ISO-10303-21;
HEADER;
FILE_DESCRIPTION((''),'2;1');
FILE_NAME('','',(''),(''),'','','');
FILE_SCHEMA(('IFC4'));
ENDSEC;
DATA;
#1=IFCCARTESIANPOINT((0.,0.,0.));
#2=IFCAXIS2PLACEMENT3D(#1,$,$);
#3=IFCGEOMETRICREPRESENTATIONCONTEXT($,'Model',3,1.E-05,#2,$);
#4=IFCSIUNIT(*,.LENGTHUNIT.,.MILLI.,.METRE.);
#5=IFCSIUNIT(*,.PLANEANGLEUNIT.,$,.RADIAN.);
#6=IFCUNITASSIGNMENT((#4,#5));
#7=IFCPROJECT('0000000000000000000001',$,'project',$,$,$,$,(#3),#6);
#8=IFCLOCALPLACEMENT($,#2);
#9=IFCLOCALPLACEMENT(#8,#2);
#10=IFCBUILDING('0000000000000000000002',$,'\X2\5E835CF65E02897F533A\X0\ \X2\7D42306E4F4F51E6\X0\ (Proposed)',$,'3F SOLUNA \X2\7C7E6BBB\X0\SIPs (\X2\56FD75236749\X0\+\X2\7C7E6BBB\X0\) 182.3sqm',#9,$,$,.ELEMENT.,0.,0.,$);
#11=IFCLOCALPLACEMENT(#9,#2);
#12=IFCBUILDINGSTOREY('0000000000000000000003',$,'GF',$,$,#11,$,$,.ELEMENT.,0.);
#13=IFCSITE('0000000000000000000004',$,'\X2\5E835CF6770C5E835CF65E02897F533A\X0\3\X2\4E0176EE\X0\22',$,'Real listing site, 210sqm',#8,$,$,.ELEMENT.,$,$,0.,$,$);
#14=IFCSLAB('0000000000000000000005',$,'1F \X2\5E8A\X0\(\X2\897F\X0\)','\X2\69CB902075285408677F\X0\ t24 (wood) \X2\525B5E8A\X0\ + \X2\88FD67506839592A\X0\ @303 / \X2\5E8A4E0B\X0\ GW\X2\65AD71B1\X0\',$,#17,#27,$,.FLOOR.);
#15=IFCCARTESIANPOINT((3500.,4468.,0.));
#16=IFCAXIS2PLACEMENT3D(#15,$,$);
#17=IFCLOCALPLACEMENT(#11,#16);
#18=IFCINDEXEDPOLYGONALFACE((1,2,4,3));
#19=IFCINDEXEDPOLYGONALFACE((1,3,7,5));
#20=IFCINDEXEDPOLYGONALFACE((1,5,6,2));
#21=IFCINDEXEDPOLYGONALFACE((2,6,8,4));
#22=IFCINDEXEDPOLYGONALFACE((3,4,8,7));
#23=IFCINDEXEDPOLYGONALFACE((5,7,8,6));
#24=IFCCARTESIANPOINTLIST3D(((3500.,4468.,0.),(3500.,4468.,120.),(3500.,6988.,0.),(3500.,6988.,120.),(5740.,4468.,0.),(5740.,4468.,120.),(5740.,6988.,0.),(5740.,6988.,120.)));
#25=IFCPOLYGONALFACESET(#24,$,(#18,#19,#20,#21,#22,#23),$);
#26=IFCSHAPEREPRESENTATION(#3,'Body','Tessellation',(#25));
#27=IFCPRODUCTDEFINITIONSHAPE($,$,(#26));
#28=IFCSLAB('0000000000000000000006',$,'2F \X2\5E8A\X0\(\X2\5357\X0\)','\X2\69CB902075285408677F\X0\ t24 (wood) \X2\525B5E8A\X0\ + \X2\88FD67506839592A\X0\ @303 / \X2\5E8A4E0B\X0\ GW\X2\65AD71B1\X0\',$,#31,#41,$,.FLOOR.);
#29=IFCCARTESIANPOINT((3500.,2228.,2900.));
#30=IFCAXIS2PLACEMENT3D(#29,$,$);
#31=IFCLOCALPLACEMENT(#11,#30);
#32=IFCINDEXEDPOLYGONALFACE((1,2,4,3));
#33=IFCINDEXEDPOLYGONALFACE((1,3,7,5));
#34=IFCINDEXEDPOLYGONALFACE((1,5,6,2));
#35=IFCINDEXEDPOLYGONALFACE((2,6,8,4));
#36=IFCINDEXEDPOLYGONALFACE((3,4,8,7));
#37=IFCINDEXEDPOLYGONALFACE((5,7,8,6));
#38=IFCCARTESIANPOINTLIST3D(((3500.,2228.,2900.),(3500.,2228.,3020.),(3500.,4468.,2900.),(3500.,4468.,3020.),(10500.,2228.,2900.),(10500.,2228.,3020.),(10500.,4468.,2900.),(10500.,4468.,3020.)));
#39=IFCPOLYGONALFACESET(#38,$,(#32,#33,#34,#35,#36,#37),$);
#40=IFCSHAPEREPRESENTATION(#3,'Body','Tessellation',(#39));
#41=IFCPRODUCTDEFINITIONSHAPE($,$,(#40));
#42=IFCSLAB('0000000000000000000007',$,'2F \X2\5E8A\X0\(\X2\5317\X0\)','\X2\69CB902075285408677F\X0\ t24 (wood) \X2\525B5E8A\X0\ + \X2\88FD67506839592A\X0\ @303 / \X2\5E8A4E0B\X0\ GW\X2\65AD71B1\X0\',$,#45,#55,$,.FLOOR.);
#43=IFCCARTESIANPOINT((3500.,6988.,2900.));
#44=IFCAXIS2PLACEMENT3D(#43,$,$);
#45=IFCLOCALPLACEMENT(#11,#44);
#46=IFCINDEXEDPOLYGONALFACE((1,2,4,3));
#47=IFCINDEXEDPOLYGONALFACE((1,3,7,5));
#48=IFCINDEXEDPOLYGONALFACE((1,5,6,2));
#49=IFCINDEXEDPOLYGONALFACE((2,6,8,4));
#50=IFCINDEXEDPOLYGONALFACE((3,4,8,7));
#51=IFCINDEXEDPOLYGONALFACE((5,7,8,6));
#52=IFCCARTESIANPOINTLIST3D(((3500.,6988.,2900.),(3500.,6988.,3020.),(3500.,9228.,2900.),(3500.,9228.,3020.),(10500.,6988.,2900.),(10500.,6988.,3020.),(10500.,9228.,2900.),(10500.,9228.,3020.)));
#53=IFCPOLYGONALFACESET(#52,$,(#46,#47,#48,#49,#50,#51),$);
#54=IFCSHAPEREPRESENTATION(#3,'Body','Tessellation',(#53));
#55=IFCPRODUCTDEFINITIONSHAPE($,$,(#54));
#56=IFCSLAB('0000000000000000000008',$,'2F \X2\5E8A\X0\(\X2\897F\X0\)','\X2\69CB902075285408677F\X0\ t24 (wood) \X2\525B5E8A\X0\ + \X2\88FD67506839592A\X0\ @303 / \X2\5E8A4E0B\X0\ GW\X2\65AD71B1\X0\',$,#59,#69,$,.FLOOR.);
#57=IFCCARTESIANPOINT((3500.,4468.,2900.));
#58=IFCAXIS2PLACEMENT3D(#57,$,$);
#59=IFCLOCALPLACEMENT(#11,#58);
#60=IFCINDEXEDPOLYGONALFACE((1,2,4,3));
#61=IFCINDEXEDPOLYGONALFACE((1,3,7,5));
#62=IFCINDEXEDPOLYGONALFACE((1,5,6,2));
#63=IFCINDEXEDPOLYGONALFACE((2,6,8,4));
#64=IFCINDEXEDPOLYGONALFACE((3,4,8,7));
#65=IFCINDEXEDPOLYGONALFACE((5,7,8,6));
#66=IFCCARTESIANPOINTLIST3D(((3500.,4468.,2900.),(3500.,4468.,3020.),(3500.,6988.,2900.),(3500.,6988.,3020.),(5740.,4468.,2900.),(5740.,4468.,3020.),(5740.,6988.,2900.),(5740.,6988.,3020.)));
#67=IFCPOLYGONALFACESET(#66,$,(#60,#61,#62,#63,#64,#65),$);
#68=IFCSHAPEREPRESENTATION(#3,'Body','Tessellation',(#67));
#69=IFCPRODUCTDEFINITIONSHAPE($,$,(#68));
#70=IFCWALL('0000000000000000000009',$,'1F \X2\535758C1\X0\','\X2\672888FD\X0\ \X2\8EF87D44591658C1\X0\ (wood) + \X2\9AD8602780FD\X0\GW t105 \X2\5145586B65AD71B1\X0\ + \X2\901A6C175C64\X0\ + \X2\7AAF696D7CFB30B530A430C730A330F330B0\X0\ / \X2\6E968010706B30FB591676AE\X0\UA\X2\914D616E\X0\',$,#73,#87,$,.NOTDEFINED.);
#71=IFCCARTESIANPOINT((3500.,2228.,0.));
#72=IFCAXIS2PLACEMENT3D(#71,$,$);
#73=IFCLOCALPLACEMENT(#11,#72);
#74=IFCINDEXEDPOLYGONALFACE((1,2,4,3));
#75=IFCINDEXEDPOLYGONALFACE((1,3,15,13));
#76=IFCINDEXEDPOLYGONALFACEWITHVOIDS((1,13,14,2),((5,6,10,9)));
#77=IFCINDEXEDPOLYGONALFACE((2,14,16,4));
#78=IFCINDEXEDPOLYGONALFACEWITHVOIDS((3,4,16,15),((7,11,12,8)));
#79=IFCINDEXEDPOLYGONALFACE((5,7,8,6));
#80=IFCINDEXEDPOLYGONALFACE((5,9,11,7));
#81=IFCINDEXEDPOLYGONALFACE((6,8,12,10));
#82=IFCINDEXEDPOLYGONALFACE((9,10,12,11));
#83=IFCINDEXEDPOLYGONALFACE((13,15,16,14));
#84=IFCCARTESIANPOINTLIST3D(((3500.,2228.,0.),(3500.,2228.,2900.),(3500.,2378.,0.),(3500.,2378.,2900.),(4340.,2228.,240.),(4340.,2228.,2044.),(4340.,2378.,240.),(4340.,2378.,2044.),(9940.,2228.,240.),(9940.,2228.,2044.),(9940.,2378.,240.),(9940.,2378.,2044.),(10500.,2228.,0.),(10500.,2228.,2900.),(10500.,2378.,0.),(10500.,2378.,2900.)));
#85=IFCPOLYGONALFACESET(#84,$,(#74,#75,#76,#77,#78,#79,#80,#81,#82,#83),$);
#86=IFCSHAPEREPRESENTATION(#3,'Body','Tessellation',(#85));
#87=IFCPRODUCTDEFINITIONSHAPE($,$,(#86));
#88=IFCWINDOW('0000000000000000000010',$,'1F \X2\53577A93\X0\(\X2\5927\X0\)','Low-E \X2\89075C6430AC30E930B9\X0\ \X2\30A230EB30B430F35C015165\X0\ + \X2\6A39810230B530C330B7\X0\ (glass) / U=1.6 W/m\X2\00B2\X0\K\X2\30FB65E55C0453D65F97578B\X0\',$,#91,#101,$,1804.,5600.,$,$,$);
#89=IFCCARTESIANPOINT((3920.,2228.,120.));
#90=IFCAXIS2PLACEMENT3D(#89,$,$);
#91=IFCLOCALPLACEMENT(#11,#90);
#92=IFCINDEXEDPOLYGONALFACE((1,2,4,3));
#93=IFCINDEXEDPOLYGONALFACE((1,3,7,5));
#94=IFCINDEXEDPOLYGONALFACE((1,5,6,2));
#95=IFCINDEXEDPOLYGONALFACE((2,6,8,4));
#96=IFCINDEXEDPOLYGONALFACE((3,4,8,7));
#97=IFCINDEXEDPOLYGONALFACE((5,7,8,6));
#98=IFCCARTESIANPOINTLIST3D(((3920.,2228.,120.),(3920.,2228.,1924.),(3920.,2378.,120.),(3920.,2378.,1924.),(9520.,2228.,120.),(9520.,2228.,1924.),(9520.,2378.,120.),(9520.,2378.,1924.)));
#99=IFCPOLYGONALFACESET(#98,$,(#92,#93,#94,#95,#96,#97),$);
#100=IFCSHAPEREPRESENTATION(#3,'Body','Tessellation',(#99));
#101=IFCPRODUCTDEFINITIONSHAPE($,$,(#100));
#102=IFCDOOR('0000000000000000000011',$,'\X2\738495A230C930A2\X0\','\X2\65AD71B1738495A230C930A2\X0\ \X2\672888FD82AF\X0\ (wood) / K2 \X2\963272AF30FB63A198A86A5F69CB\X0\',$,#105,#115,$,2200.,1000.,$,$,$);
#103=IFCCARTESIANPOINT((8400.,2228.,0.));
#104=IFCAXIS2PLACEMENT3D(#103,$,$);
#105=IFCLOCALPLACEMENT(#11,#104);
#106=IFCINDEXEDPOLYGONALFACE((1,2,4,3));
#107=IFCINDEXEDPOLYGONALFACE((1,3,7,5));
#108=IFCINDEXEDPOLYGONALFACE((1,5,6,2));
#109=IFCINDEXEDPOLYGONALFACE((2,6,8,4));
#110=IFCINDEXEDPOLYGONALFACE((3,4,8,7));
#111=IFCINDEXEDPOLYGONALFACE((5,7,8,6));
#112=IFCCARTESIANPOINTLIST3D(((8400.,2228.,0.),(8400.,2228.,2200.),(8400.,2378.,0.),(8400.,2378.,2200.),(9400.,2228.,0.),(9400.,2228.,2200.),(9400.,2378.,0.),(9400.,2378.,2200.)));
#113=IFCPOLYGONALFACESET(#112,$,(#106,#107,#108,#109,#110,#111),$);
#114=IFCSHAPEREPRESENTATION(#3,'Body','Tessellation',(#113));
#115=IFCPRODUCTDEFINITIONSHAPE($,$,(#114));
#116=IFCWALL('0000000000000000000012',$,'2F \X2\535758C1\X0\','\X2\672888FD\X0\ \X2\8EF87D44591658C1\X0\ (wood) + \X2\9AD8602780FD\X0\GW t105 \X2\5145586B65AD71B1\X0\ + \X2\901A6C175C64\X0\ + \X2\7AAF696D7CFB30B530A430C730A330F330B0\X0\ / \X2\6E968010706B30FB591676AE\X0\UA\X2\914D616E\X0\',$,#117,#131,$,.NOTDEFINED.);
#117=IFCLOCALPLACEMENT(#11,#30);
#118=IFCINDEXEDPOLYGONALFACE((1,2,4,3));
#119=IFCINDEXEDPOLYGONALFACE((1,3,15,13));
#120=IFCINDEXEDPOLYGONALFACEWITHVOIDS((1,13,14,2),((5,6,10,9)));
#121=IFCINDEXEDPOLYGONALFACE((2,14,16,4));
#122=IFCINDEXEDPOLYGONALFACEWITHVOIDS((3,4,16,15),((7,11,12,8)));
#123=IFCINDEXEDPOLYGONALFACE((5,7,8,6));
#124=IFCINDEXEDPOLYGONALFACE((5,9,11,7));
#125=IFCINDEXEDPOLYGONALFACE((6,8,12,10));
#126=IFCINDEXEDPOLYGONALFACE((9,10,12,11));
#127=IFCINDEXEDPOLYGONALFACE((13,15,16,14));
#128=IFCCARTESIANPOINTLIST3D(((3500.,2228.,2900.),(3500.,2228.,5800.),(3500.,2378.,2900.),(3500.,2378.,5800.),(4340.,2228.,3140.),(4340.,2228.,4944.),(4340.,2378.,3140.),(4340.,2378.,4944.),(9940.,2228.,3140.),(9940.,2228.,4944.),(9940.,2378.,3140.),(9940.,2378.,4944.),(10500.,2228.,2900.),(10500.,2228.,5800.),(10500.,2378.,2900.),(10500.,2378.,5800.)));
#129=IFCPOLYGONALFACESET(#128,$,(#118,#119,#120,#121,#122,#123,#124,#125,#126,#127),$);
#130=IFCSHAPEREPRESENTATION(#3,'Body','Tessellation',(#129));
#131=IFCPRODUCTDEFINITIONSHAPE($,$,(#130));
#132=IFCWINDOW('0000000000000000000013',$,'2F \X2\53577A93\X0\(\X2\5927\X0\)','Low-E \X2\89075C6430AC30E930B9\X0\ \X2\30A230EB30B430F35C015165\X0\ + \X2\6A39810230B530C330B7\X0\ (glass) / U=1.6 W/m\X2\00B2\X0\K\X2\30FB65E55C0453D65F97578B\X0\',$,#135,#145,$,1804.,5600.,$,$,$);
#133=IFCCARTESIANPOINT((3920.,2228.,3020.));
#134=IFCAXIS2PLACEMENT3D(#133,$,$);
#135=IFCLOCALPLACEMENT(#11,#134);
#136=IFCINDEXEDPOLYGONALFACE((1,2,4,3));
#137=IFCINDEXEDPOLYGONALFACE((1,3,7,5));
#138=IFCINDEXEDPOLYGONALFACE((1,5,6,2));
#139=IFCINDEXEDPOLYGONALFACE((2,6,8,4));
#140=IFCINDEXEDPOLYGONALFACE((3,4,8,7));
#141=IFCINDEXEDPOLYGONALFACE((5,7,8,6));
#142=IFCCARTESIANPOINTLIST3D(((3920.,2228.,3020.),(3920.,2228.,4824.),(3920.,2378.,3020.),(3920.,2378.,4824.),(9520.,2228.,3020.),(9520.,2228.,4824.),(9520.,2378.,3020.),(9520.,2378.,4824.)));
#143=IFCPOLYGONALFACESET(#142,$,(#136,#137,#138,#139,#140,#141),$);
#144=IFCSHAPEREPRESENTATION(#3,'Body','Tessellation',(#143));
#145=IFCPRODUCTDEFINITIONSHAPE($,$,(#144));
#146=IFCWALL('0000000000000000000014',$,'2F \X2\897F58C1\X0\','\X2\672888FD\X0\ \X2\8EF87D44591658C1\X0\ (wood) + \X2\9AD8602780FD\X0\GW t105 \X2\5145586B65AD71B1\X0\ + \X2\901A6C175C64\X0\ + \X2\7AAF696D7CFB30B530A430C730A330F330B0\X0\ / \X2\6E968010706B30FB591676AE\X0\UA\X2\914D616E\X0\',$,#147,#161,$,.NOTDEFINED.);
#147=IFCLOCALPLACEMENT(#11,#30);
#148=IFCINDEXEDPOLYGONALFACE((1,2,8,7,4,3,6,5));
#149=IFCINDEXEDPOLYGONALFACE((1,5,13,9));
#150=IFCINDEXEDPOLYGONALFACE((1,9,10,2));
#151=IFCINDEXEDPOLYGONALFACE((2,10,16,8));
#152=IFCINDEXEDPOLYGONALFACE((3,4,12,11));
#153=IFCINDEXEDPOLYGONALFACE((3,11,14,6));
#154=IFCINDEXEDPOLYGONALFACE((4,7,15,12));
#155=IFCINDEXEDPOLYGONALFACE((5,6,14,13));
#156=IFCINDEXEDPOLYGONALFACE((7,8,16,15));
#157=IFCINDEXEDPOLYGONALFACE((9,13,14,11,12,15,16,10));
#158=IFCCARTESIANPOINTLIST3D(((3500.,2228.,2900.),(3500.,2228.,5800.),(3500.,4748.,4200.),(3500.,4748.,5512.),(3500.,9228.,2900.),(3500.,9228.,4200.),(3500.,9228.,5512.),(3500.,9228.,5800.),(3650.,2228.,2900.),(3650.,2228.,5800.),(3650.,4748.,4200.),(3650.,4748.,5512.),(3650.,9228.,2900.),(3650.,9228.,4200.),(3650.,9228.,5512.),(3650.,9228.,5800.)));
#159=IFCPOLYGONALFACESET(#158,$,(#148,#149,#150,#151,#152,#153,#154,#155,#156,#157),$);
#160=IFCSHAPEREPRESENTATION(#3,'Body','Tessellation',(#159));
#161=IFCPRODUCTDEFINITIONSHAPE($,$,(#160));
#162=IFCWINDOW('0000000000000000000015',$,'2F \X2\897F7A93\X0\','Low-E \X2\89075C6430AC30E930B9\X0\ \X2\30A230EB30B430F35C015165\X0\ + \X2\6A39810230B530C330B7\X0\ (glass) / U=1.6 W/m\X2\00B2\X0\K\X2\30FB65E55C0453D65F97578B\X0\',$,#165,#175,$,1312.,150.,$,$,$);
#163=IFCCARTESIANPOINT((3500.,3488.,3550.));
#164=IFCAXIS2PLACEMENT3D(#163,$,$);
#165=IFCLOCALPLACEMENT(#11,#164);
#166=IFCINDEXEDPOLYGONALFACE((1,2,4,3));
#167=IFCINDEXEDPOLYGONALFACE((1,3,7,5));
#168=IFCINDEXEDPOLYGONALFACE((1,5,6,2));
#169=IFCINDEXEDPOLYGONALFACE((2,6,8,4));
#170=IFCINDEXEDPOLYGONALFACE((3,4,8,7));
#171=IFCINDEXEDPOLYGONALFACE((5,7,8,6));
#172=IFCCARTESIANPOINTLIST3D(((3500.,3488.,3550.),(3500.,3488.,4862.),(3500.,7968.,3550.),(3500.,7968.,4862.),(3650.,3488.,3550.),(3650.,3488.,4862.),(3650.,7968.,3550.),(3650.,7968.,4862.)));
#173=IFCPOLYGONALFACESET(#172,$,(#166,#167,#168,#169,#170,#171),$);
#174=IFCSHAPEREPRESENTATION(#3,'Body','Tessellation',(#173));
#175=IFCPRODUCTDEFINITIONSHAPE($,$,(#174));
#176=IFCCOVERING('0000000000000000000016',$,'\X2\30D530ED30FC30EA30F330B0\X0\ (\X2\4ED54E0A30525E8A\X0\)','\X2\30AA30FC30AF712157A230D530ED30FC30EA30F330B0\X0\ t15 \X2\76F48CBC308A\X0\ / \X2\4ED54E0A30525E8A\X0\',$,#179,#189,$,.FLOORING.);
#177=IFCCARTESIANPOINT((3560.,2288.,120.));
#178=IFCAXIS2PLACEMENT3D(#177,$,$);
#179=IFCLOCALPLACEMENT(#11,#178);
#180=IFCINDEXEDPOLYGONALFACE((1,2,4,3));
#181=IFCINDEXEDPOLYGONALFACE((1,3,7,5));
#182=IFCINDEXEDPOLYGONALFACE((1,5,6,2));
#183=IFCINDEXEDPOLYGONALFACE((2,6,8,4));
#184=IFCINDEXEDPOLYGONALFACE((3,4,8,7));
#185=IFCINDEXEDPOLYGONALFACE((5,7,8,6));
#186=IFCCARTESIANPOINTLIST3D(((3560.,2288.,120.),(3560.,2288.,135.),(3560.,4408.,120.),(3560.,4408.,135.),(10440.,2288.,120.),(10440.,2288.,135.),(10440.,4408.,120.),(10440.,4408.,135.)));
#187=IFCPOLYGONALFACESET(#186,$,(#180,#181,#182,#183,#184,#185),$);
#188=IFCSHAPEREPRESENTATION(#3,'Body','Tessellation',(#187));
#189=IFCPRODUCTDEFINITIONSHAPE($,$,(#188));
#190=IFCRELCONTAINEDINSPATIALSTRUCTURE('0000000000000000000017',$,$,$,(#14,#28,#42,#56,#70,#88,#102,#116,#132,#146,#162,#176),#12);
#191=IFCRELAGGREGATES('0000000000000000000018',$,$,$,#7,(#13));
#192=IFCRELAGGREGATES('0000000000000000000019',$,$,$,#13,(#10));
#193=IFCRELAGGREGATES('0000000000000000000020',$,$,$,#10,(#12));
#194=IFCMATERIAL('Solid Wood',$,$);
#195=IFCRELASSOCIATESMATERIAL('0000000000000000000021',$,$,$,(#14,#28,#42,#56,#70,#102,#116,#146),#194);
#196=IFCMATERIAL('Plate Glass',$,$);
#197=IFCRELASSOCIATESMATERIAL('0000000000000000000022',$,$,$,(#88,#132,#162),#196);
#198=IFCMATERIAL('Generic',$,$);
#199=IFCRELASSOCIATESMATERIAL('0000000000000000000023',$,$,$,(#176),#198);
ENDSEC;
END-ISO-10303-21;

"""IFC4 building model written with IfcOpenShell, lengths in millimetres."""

from ifc_helpers import new_model, si_unit, frame, frame_2d, origin, place, context, project, spatial, rectangle, extrude, material, element, fill, save


model = new_model("IFC4")

# Units and contexts
model_context = context("Model", 3, precision=1e-05, world=origin())
ifc_project = project(units=[si_unit("LENGTHUNIT", "METRE", prefix="MILLI"), si_unit("PLANEANGLEUNIT", "RADIAN")], contexts=[model_context])

# Site, building, storey
site_placement = place(None, origin())
site = spatial("IfcSite", under=ifc_project, at=site_placement, Name="広島県広島市西区3丁目22", ObjectType="Real listing site, 210sqm", CompositionType="ELEMENT", RefElevation=0.0)
building_placement = place(site_placement, origin())
building = spatial("IfcBuilding", under=site, at=building_placement, Name="広島市西区 終の住処 (Proposed)", ObjectType="3F SOLUNA 籾殻SIPs (国産杉+籾殻) 182.3sqm", CompositionType="ELEMENT", ElevationOfRefHeight=0.0, ElevationOfTerrain=0.0)
storey_placement = place(building_placement, origin())
storey = spatial("IfcBuildingStorey", under=building, at=storey_placement, Name="GF", CompositionType="ELEMENT", Elevation=0.0)

# Slabs
ifc_material_1 = material(Name="Solid Wood")
slab_1_placement = place(storey_placement, frame((3500.0, 4468.0, 0.0)))
element("IfcSlab", 1, at=slab_1_placement, inside=storey, material=ifc_material_1, Name="1F 床(西)", Description="構造用合板 t24 (wood) 剛床 + 製材根太 @303 / 床下 GW断熱", PredefinedType="FLOOR", context=model_context, shape_type="SweptSolid", body=[
    extrude(rectangle(XDim=2240.0, YDim=2520.0, at=frame_2d((1120.0, 1260.0))), frame((3500.0, 4468.0, 0.0)), (0.0, 0.0, 1.0), 120.0),
])
slab_2_placement = place(storey_placement, frame((3500.0, 2228.0, 2900.0)))
element("IfcSlab", 2, at=slab_2_placement, inside=storey, material=ifc_material_1, Name="2F 床(南)", Description="構造用合板 t24 (wood) 剛床 + 製材根太 @303 / 床下 GW断熱", PredefinedType="FLOOR", context=model_context, shape_type="SweptSolid", body=[
    extrude(rectangle(XDim=7000.0, YDim=2240.0, at=frame_2d((3500.0, 1120.0))), frame((3500.0, 2228.0, 2900.0)), (0.0, 0.0, 1.0), 120.0),
])
slab_3_placement = place(storey_placement, frame((3500.0, 6988.0, 2900.0)))
element("IfcSlab", 3, at=slab_3_placement, inside=storey, material=ifc_material_1, Name="2F 床(北)", Description="構造用合板 t24 (wood) 剛床 + 製材根太 @303 / 床下 GW断熱", PredefinedType="FLOOR", context=model_context, shape_type="SweptSolid", body=[
    extrude(rectangle(XDim=7000.0, YDim=2240.0, at=frame_2d((3500.0, 1120.0))), frame((3500.0, 6988.0, 2900.0)), (0.0, 0.0, 1.0), 120.0),
])
slab_4_placement = place(storey_placement, frame((3500.0, 4468.0, 2900.0)))
element("IfcSlab", 4, at=slab_4_placement, inside=storey, material=ifc_material_1, Name="2F 床(西)", Description="構造用合板 t24 (wood) 剛床 + 製材根太 @303 / 床下 GW断熱", PredefinedType="FLOOR", context=model_context, shape_type="SweptSolid", body=[
    extrude(rectangle(XDim=2240.0, YDim=2520.0, at=frame_2d((1120.0, 1260.0))), frame((3500.0, 4468.0, 2900.0)), (0.0, 0.0, 1.0), 120.0),
])

# Wall, openings, window, door
wall_1_placement = place(storey_placement, frame((3500.0, 2228.0, 0.0)))
wall_1 = element("IfcWall", 5, at=wall_1_placement, inside=storey, material=ifc_material_1, Name="1F 南壁", Description="木製 軸組外壁 (wood) + 高性能GW t105 充填断熱 + 通気層 + 窯業系サイディング / 準耐火・外皮UA配慮", PredefinedType="NOTDEFINED", context=model_context, shape_type="SweptSolid", body=[
    extrude(rectangle(XDim=7000.0, YDim=150.0, at=frame_2d((3500.0, 75.0))), frame((3500.0, 2228.0, 0.0)), (0.0, 0.0, 1.0), 2900.0),
])
opening_1_placement = place(storey_placement, frame((3920.0, 2228.0, 120.0)))
opening_1 = element("IfcOpeningElement", 6, at=opening_1_placement, cuts=wall_1, PredefinedType="NOTDEFINED", context=model_context, shape_type="SweptSolid", body=[
    extrude(rectangle(XDim=5600.0, YDim=150.0, at=frame_2d((2800.0, 75.0))), frame((3920.0, 2228.0, 120.0)), (0.0, 0.0, 1.0), 1804.0),
])
opening_2_placement = place(storey_placement, frame((8400.0, 2228.0, 0.0)))
opening_2 = element("IfcOpeningElement", 7, at=opening_2_placement, cuts=wall_1, PredefinedType="NOTDEFINED", context=model_context, shape_type="SweptSolid", body=[
    extrude(rectangle(XDim=1000.0, YDim=150.0, at=frame_2d((500.0, 75.0))), frame((8400.0, 2228.0, 0.0)), (0.0, 0.0, 1.0), 2200.0),
])
ifc_material_2 = material(Name="Plate Glass")
window_1_placement = place(storey_placement, frame((3920.0, 2228.0, 120.0)))
window_1 = element("IfcWindow", 8, at=window_1_placement, inside=storey, material=ifc_material_2, Name="1F 南窓(大)", Description="Low-E 複層ガラス アルゴン封入 + 樹脂サッシ (glass) / U=1.6 W/m²K・日射取得型", OverallHeight=1804.0, OverallWidth=5600.0, context=model_context, shape_type="SweptSolid", body=[
    extrude(rectangle(XDim=5600.0, YDim=150.0, at=frame_2d((2800.0, 75.0))), frame((3920.0, 2228.0, 120.0)), (0.0, 0.0, 1.0), 1804.0),
])
fill(opening_1, window_1)
door_placement = place(storey_placement, frame((8400.0, 2228.0, 0.0)))
door = element("IfcDoor", 9, at=door_placement, inside=storey, material=ifc_material_1, Name="玄関ドア", Description="断熱玄関ドア 木製芯 (wood) / K2 防犯・採風機構", OverallHeight=2200.0, OverallWidth=1000.0, context=model_context, shape_type="SweptSolid", body=[
    extrude(rectangle(XDim=1000.0, YDim=150.0, at=frame_2d((500.0, 75.0))), frame((8400.0, 2228.0, 0.0)), (0.0, 0.0, 1.0), 2200.0),
])
fill(opening_2, door)

# Wall, opening, window
wall_2_placement = place(storey_placement, frame((3500.0, 2228.0, 2900.0)))
wall_2 = element("IfcWall", 10, at=wall_2_placement, inside=storey, material=ifc_material_1, Name="2F 南壁", Description="木製 軸組外壁 (wood) + 高性能GW t105 充填断熱 + 通気層 + 窯業系サイディング / 準耐火・外皮UA配慮", PredefinedType="NOTDEFINED", context=model_context, shape_type="SweptSolid", body=[
    extrude(rectangle(XDim=7000.0, YDim=150.0, at=frame_2d((3500.0, 75.0))), frame((3500.0, 2228.0, 2900.0)), (0.0, 0.0, 1.0), 2900.0),
])
opening_3_placement = place(storey_placement, frame((3920.0, 2228.0, 3020.0)))
opening_3 = element("IfcOpeningElement", 11, at=opening_3_placement, cuts=wall_2, PredefinedType="NOTDEFINED", context=model_context, shape_type="SweptSolid", body=[
    extrude(rectangle(XDim=5600.0, YDim=150.0, at=frame_2d((2800.0, 75.0))), frame((3920.0, 2228.0, 3020.0)), (0.0, 0.0, 1.0), 1804.0),
])
window_2_placement = place(storey_placement, frame((3920.0, 2228.0, 3020.0)))
window_2 = element("IfcWindow", 12, at=window_2_placement, inside=storey, material=ifc_material_2, Name="2F 南窓(大)", Description="Low-E 複層ガラス アルゴン封入 + 樹脂サッシ (glass) / U=1.6 W/m²K・日射取得型", OverallHeight=1804.0, OverallWidth=5600.0, context=model_context, shape_type="SweptSolid", body=[
    extrude(rectangle(XDim=5600.0, YDim=150.0, at=frame_2d((2800.0, 75.0))), frame((3920.0, 2228.0, 3020.0)), (0.0, 0.0, 1.0), 1804.0),
])
fill(opening_3, window_2)

# Wall, opening, window
wall_3_placement = place(storey_placement, frame((3500.0, 2228.0, 2900.0)))
wall_3 = element("IfcWall", 13, at=wall_3_placement, inside=storey, material=ifc_material_1, Name="2F 西壁", Description="木製 軸組外壁 (wood) + 高性能GW t105 充填断熱 + 通気層 + 窯業系サイディング / 準耐火・外皮UA配慮", PredefinedType="NOTDEFINED", context=model_context, shape_type="SweptSolid", body=[
    extrude(rectangle(XDim=150.0, YDim=7000.0, at=frame_2d((75.0, 3500.0))), frame((3500.0, 2228.0, 2900.0)), (0.0, 0.0, 1.0), 2900.0),
])
opening_4_placement = place(storey_placement, frame((3500.0, 3488.0, 3550.0)))
opening_4 = element("IfcOpeningElement", 14, at=opening_4_placement, cuts=wall_3, PredefinedType="NOTDEFINED", context=model_context, shape_type="SweptSolid", body=[
    extrude(rectangle(XDim=150.0, YDim=4480.0, at=frame_2d((75.0, 2240.0))), frame((3500.0, 3488.0, 3550.0)), (0.0, 0.0, 1.0), 1312.0),
])
window_3_placement = place(storey_placement, frame((3500.0, 3488.0, 3550.0)))
window_3 = element("IfcWindow", 15, at=window_3_placement, inside=storey, material=ifc_material_2, Name="2F 西窓", Description="Low-E 複層ガラス アルゴン封入 + 樹脂サッシ (glass) / U=1.6 W/m²K・日射取得型", OverallHeight=1312.0, OverallWidth=150.0, context=model_context, shape_type="SweptSolid", body=[
    extrude(rectangle(XDim=150.0, YDim=4480.0, at=frame_2d((75.0, 2240.0))), frame((3500.0, 3488.0, 3550.0)), (0.0, 0.0, 1.0), 1312.0),
])
fill(opening_4, window_3)

# Covering
ifc_material_3 = material(Name="Generic")
covering_1_placement = place(storey_placement, frame((3560.0, 2288.0, 120.0)))
element("IfcCovering", 16, at=covering_1_placement, inside=storey, material=ifc_material_3, Name="フローリング (仕上げ床)", Description="オーク無垢フローリング t15 直貼り / 仕上げ床", PredefinedType="FLOORING", context=model_context, shape_type="SweptSolid", body=[
    extrude(rectangle(XDim=6880.0, YDim=2120.0, at=frame_2d((3440.0, 1060.0))), frame((3560.0, 2288.0, 120.0)), (0.0, 0.0, 1.0), 15.0),
])

save(model, "model.ifc")
